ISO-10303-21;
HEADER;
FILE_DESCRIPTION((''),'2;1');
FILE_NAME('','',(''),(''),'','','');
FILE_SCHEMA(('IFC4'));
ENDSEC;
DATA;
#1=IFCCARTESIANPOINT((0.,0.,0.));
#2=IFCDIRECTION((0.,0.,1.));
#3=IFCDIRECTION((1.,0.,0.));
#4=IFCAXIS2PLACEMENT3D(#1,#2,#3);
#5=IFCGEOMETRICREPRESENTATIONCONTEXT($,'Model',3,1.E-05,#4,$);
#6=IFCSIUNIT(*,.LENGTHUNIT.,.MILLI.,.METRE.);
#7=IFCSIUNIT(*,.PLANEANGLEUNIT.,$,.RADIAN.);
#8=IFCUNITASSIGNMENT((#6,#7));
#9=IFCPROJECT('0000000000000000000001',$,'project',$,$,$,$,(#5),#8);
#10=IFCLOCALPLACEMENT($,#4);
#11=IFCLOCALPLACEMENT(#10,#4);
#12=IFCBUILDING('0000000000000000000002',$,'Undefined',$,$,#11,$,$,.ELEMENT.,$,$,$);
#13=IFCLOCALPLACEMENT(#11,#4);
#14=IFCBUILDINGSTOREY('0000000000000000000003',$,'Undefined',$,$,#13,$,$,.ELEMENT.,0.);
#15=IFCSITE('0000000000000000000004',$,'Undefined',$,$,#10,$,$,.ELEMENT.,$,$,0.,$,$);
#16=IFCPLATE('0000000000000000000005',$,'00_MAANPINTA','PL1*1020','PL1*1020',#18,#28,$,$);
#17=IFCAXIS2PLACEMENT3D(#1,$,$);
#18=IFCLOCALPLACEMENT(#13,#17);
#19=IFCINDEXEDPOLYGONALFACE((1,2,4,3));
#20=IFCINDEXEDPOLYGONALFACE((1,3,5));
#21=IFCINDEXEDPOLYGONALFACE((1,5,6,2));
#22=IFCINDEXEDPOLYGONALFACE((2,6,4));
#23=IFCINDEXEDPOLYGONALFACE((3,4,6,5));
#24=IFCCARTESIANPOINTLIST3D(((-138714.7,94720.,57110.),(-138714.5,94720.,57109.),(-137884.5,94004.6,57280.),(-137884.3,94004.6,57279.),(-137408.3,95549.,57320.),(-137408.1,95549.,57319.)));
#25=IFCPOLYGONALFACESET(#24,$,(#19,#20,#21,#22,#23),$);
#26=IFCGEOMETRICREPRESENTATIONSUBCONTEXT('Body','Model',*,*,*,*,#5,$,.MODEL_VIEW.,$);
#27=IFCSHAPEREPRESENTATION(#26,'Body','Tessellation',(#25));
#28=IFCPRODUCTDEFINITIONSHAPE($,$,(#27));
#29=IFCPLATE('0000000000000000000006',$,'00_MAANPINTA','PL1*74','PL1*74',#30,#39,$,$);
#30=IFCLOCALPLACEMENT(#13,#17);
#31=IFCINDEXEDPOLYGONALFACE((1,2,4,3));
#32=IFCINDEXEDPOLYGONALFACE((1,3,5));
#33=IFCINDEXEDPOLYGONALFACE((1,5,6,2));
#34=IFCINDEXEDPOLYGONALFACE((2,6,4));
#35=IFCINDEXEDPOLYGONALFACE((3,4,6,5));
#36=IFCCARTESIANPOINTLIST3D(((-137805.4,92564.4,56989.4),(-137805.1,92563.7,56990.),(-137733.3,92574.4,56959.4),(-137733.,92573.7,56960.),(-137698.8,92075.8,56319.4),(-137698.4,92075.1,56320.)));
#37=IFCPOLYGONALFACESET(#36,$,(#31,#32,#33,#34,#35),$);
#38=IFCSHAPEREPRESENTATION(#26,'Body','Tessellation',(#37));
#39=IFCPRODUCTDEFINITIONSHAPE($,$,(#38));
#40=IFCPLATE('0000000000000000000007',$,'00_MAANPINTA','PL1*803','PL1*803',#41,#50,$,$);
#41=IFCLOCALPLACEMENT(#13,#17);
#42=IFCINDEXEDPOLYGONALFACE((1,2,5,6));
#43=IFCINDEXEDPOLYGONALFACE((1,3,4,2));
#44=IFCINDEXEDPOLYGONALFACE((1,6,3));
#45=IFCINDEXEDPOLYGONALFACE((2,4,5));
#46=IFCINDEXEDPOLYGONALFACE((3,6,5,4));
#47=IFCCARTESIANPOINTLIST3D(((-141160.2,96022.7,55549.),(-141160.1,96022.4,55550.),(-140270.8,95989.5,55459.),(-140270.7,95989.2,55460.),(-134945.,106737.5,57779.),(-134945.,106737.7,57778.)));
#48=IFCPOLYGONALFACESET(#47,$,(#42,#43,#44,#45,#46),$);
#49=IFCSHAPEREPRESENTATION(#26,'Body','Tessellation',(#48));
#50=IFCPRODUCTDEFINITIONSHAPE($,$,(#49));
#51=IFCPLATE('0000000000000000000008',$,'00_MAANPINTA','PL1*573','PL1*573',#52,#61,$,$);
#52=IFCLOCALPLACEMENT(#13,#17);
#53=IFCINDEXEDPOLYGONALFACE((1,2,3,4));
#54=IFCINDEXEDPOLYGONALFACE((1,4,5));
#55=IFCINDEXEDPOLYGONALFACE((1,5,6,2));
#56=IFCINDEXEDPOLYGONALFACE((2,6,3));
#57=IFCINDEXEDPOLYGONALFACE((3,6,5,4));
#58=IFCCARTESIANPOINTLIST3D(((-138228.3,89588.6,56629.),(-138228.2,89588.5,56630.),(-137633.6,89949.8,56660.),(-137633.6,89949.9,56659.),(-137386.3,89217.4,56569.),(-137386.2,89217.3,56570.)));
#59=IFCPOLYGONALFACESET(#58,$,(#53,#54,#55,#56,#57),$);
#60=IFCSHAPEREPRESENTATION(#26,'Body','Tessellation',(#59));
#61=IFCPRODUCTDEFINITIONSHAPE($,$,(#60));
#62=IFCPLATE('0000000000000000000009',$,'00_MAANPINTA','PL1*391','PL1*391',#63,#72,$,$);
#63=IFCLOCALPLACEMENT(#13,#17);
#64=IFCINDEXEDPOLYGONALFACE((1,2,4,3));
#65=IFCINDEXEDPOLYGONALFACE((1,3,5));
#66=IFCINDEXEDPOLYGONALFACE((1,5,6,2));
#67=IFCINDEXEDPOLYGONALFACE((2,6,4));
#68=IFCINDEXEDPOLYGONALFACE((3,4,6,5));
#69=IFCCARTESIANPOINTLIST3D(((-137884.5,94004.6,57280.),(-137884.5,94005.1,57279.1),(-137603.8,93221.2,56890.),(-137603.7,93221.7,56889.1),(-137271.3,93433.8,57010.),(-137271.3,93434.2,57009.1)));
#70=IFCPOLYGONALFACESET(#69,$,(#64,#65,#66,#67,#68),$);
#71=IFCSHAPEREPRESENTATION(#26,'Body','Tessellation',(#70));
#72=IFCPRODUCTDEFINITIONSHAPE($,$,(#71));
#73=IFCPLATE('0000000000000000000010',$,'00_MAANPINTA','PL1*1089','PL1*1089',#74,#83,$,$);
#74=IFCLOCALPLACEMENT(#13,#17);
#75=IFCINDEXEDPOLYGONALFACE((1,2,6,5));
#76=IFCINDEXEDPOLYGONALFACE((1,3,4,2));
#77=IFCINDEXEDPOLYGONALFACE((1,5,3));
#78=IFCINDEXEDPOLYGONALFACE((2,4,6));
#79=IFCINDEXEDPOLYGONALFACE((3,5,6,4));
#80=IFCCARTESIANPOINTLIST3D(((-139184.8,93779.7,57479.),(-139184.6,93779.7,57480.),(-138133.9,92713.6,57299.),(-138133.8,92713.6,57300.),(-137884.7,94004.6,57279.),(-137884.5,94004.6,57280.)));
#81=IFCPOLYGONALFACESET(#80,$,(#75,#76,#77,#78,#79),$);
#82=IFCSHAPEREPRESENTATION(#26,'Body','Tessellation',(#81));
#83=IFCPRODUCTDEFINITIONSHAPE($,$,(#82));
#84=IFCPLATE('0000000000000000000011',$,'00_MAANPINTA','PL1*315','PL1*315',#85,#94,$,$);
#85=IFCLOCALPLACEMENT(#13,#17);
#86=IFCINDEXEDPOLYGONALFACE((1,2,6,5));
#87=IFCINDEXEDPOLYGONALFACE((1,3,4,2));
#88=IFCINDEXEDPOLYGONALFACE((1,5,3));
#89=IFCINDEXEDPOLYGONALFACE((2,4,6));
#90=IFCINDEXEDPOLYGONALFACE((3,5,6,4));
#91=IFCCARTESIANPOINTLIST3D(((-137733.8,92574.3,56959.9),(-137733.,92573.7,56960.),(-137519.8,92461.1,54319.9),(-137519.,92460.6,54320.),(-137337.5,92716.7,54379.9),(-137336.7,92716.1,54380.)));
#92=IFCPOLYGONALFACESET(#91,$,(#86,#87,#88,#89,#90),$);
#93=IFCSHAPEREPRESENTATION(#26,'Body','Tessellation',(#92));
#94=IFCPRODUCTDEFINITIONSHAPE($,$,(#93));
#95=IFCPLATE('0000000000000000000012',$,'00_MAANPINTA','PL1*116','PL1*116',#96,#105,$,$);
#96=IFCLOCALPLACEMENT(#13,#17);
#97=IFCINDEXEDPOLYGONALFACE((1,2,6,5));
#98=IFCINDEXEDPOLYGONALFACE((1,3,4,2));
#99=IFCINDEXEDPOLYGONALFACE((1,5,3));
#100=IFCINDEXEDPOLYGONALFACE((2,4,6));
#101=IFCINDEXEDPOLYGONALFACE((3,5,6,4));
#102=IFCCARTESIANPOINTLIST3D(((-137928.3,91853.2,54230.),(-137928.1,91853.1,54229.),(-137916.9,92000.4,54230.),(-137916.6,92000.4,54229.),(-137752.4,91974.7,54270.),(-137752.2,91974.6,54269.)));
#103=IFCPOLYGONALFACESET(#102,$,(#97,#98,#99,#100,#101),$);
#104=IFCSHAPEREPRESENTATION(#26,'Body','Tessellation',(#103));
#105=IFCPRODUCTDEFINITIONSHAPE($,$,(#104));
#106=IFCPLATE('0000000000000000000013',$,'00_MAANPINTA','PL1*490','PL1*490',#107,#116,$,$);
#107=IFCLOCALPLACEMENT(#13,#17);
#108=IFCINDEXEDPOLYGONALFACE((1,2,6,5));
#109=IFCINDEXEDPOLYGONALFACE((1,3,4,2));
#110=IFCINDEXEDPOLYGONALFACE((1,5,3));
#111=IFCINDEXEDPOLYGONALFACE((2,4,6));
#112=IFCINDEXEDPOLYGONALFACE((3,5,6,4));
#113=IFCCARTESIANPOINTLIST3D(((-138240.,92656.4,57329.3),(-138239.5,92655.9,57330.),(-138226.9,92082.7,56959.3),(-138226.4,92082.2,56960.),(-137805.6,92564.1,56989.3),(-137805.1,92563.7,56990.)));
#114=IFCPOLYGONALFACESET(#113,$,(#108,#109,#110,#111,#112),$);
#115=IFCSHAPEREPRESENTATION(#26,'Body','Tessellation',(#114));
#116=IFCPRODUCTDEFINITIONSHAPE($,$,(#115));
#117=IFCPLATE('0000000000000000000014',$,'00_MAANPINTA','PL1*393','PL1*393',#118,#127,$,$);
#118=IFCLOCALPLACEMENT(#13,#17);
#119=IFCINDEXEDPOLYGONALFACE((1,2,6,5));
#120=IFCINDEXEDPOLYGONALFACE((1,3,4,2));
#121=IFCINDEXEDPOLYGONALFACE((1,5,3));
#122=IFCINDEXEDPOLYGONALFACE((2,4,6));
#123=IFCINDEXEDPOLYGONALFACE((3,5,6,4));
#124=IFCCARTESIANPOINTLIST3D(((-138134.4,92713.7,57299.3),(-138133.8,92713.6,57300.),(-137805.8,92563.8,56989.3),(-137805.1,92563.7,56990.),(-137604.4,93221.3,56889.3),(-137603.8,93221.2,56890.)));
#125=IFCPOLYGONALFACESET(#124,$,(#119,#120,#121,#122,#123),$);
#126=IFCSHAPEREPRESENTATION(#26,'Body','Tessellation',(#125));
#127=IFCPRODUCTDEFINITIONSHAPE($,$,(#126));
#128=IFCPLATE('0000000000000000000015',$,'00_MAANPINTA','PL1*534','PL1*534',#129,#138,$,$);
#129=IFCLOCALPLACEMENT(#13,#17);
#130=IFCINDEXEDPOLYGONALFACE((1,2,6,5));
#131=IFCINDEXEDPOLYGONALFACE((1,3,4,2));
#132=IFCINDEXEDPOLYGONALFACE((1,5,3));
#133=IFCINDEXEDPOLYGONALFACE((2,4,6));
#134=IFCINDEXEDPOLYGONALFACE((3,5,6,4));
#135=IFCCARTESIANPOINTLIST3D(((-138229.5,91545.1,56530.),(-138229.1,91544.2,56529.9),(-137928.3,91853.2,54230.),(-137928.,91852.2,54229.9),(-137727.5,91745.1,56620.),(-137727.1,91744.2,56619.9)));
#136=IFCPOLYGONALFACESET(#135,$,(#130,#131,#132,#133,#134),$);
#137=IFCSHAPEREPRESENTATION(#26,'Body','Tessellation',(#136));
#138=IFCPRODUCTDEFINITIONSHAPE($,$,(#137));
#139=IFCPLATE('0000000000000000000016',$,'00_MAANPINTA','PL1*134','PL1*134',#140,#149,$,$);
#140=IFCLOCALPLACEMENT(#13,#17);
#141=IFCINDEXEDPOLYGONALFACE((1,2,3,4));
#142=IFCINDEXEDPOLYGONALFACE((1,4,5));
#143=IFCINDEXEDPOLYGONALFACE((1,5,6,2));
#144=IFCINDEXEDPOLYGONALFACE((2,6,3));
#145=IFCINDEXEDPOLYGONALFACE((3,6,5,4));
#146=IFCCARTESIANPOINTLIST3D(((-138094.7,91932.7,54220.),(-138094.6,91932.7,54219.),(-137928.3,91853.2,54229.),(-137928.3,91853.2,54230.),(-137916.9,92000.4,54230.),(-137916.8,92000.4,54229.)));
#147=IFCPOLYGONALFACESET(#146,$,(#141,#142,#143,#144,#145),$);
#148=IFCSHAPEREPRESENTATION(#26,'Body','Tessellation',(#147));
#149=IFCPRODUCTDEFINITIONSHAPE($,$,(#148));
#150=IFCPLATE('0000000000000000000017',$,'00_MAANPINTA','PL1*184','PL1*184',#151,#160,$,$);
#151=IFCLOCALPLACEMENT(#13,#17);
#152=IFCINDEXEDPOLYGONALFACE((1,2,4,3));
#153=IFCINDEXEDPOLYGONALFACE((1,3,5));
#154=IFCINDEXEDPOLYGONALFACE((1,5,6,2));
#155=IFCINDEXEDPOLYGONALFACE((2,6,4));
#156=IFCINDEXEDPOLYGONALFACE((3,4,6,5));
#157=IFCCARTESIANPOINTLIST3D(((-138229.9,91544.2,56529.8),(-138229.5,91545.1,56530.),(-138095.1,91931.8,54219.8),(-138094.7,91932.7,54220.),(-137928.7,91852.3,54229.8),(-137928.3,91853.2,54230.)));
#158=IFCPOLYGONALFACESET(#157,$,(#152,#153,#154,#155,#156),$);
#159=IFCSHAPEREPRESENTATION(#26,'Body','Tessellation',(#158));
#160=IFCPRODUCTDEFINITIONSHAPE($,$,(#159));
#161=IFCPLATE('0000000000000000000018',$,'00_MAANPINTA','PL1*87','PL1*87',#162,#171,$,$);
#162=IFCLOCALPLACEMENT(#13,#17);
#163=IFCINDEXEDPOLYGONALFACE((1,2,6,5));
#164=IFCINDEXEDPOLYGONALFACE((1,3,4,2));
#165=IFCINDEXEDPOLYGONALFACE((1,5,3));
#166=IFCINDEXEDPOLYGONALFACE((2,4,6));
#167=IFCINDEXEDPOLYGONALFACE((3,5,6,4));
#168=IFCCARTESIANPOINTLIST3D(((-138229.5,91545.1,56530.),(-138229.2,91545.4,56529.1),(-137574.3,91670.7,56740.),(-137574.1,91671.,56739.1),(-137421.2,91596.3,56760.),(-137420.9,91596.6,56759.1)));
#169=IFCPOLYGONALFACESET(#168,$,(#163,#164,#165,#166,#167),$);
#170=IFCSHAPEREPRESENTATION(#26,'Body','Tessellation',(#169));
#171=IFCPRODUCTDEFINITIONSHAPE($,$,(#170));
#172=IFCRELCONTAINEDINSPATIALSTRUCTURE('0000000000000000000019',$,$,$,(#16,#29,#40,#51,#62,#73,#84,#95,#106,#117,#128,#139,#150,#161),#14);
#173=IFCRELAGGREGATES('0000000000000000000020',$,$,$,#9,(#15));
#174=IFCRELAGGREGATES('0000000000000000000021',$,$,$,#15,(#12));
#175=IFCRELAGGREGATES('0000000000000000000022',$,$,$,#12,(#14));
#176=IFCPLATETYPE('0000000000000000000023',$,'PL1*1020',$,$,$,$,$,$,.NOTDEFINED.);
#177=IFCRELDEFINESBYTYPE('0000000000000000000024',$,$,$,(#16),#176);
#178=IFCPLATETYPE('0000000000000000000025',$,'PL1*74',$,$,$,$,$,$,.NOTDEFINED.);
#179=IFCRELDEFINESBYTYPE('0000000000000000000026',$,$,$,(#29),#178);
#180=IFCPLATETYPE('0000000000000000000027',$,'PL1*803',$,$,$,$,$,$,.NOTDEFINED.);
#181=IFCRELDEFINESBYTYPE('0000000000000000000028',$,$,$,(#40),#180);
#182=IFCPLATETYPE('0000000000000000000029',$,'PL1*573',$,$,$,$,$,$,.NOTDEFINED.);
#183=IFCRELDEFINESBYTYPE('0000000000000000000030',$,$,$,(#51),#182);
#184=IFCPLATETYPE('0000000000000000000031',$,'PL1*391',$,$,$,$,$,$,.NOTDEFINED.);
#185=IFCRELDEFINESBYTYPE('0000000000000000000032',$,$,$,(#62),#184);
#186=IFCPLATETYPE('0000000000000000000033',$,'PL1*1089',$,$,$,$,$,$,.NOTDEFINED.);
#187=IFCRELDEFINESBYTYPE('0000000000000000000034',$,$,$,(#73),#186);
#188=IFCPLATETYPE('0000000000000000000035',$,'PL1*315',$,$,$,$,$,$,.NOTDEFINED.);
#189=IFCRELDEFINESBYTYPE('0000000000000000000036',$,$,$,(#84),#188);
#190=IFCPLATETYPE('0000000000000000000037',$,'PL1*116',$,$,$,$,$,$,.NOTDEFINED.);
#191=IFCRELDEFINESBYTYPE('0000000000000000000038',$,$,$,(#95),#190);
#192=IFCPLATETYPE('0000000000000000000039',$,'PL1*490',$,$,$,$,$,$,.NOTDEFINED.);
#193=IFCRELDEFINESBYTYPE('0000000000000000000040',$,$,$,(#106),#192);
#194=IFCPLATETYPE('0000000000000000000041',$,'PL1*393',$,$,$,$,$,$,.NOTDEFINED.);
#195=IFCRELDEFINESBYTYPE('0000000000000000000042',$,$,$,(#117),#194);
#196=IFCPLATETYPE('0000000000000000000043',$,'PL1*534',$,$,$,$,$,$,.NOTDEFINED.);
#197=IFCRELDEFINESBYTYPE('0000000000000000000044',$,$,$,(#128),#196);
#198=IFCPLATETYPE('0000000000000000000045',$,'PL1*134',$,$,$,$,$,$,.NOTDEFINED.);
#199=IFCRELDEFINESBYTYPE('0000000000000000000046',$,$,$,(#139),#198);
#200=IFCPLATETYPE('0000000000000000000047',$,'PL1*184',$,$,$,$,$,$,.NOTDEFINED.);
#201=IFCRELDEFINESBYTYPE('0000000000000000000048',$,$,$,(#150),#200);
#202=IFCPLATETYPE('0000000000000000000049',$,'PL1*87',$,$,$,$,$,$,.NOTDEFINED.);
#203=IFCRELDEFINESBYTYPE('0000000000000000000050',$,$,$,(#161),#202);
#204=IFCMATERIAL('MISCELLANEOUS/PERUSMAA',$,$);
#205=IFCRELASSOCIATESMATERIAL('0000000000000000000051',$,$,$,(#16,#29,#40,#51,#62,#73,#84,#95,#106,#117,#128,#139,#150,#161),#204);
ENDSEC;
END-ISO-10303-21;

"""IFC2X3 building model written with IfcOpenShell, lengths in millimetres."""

from ifc_helpers import new_model, si_unit, frame, origin_with_axes, place, context, subcontext, project, spatial, polyline, outline, extrude, material, type_object, element, save


model = new_model("IFC2X3")

# Units and contexts
model_context = context("Model", 3, precision=1e-05, world=origin_with_axes())
body_context = subcontext(model_context, "Body", "Model", "MODEL_VIEW")
ifc_project = project(units=[si_unit("LENGTHUNIT", "METRE", prefix="MILLI"), si_unit("PLANEANGLEUNIT", "RADIAN")], contexts=[model_context])

# Site, building, storey
site_placement = place(None, origin_with_axes())
site = spatial("IfcSite", under=ifc_project, at=site_placement, Name="Undefined", CompositionType="ELEMENT", RefElevation=0.0)
building_placement = place(site_placement, origin_with_axes())
building = spatial("IfcBuilding", under=site, at=building_placement, Name="Undefined", CompositionType="ELEMENT")
storey_placement = place(building_placement, origin_with_axes())
storey = spatial("IfcBuildingStorey", under=building, at=storey_placement, Name="Undefined", CompositionType="ELEMENT", Elevation=0.0)

# Plates
ifc_material = material(Name="MISCELLANEOUS/PERUSMAA")
plate_type_1 = type_object("IfcPlateType", Name="PL1*1020", PredefinedType="NOTDEFINED")
plate_1_placement = place(storey_placement, frame((-138714.6, 94720.0, 57109.5), z_axis=(0.17653, -0.028947, -0.98387), x_axis=(0.836665, 0.530945, 0.134497)))
element("IfcPlate", 1, at=plate_1_placement, inside=storey, type_object=plate_type_1, material=ifc_material, Name="00_MAANPINTA", Description="PL1*1020", ObjectType="PL1*1020", context=body_context, shape_type="SweptSolid", body=[
    extrude(outline(polyline([(0.0, 0.0), (1561.4, 0.0), (337.6, 1056.4), (0.0, 0.0)])), frame((0.0, 0.0, -0.5), z_axis=(0.0, 0.0, 1.0), x_axis=(1.0, 0.0, 0.0)), (0.0, 0.0, 1.0), 1.0),
])
plate_type_2 = type_object("IfcPlateType", Name="PL1*74", PredefinedType="NOTDEFINED")
plate_2_placement = place(storey_placement, frame((-137805.3, 92564.0, 56989.7), z_axis=(-0.346171, 0.730931, -0.588138), x_axis=(0.91579, 0.127151, -0.381)))
element("IfcPlate", 2, at=plate_2_placement, inside=storey, type_object=plate_type_2, material=ifc_material, Name="00_MAANPINTA", Description="PL1*74", ObjectType="PL1*74", context=body_context, shape_type="SweptSolid", body=[
    extrude(outline(polyline([(0.0, 0.0), (78.7, 0.0), (290.8, 783.8), (0.0, 0.0)])), frame((0.0, 0.0, -0.5), z_axis=(0.0, 0.0, 1.0), x_axis=(1.0, 0.0, 0.0)), (0.0, 0.0, 1.0), 1.0),
])
plate_type_3 = type_object("IfcPlateType", Name="PL1*803", PredefinedType="NOTDEFINED")
plate_3_placement = place(storey_placement, frame((-140270.8, 95989.3, 55459.5), z_axis=(-0.088133, 0.251616, -0.963806), x_axis=(-0.994232, 0.037139, 0.10061)))
element("IfcPlate", 3, at=plate_3_placement, inside=storey, type_object=plate_type_3, material=ifc_material, Name="00_MAANPINTA", Description="PL1*803", ObjectType="PL1*803", context=body_context, shape_type="SweptSolid", body=[
    extrude(outline(polyline([(0.0, 0.0), (894.5, 0.0), (-4662.6, 11292.8), (0.0, 0.0)])), frame((0.0, 0.0, -0.5), z_axis=(0.0, 0.0, 1.0), x_axis=(1.0, 0.0, 0.0)), (0.0, 0.0, 1.0), 1.0),
])
plate_type_4 = type_object("IfcPlateType", Name="PL1*573", PredefinedType="NOTDEFINED")
plate_4_placement = place(storey_placement, frame((-138228.3, 89588.6, 56629.5), z_axis=(-0.019941, 0.115282, -0.993133), x_axis=(0.853834, 0.51876, 0.043073)))
element("IfcPlate", 4, at=plate_4_placement, inside=storey, type_object=plate_type_4, material=ifc_material, Name="00_MAANPINTA", Description="PL1*573", ObjectType="PL1*573", context=body_context, shape_type="SweptSolid", body=[
    extrude(outline(polyline([(0.0, 0.0), (696.5, 0.0), (523.8, 759.0), (0.0, 0.0)])), frame((0.0, 0.0, -0.5), z_axis=(0.0, 0.0, 1.0), x_axis=(1.0, 0.0, 0.0)), (0.0, 0.0, 1.0), 1.0),
])
plate_type_5 = type_object("IfcPlateType", Name="PL1*391", PredefinedType="NOTDEFINED")
plate_5_placement = place(storey_placement, frame((-137884.5, 94004.8, 57279.6), z_axis=(0.030883, 0.4543, -0.890313), x_axis=(0.696643, -0.648527, -0.306759)))
element("IfcPlate", 5, at=plate_5_placement, inside=storey, type_object=plate_type_5, material=ifc_material, Name="00_MAANPINTA", Description="PL1*391", ObjectType="PL1*391", context=body_context, shape_type="SweptSolid", body=[
    extrude(outline(polyline([(0.0, 0.0), (880.2, 0.0), (823.2, 408.5), (0.0, 0.0)])), frame((0.0, 0.0, -0.5), z_axis=(0.0, 0.0, 1.0), x_axis=(1.0, 0.0, 0.0)), (0.0, 0.0, 1.0), 1.0),
])
plate_type_6 = type_object("IfcPlateType", Name="PL1*1089", PredefinedType="NOTDEFINED")
plate_6_placement = place(storey_placement, frame((-139184.7, 93779.7, 57479.5), z_axis=(-0.154485, 0.014523, -0.987888), x_axis=(0.974238, 0.168521, -0.149873)))
element("IfcPlate", 6, at=plate_6_placement, inside=storey, type_object=plate_type_6, material=ifc_material, Name="00_MAANPINTA", Description="PL1*1089", ObjectType="PL1*1089", context=body_context, shape_type="SweptSolid", body=[
    extrude(outline(polyline([(0.0, 0.0), (1334.5, 0.0), (871.1, 1230.7), (0.0, 0.0)])), frame((0.0, 0.0, -0.5), z_axis=(0.0, 0.0, 1.0), x_axis=(1.0, 0.0, 0.0)), (0.0, 0.0, 1.0), 1.0),
])
plate_type_7 = type_object("IfcPlateType", Name="PL1*315", PredefinedType="NOTDEFINED")
plate_7_placement = place(storey_placement, frame((-137733.4, 92574.0, 56960.0), z_axis=(-0.800653, 0.592287, -0.090286), x_axis=(0.151586, 0.054468, -0.986942)))
element("IfcPlate", 7, at=plate_7_placement, inside=storey, type_object=plate_type_7, material=ifc_material, Name="00_MAANPINTA", Description="PL1*315", ObjectType="PL1*315", context=body_context, shape_type="SweptSolid", body=[
    extrude(outline(polyline([(0.0, 0.0), (2614.1, 0.0), (2631.8, 319.0), (0.0, 0.0)])), frame((0.0, 0.0, -0.5), z_axis=(0.0, 0.0, 1.0), x_axis=(1.0, 0.0, 0.0)), (0.0, 0.0, 1.0), 1.0),
])
plate_type_8 = type_object("IfcPlateType", Name="PL1*116", PredefinedType="NOTDEFINED")
plate_8_placement = place(storey_placement, frame((-137916.8, 92000.4, 54229.5), z_axis=(0.233639, -0.018186, -0.972153), x_axis=(0.960645, -0.150179, 0.233682)))
element("IfcPlate", 8, at=plate_8_placement, inside=storey, type_object=plate_type_8, material=ifc_material, Name="00_MAANPINTA", Description="PL1*116", ObjectType="PL1*116", context=body_context, shape_type="SweptSolid", body=[
    extrude(outline(polyline([(0.0, 0.0), (171.2, 0.0), (11.1, 147.2), (0.0, 0.0)])), frame((0.0, 0.0, -0.5), z_axis=(0.0, 0.0, 1.0), x_axis=(1.0, 0.0, 0.0)), (0.0, 0.0, 1.0), 1.0),
])
plate_type_9 = type_object("IfcPlateType", Name="PL1*490", PredefinedType="NOTDEFINED")
plate_9_placement = place(storey_placement, frame((-138226.6, 92082.4, 56959.6), z_axis=(-0.48125, 0.467324, -0.741625), x_axis=(-0.019169, 0.840227, 0.541896)))
element("IfcPlate", 9, at=plate_9_placement, inside=storey, type_object=plate_type_9, material=ifc_material, Name="00_MAANPINTA", Description="PL1*490", ObjectType="PL1*490", context=body_context, shape_type="SweptSolid", body=[
    extrude(outline(polyline([(0.0, 0.0), (682.8, 0.0), (412.7, 489.8), (0.0, 0.0)])), frame((0.0, 0.0, -0.5), z_axis=(0.0, 0.0, 1.0), x_axis=(1.0, 0.0, 0.0)), (0.0, 0.0, 1.0), 1.0),
])
plate_type_10 = type_object("IfcPlateType", Name="PL1*393", PredefinedType="NOTDEFINED")
plate_10_placement = place(storey_placement, frame((-137805.4, 92563.7, 56989.6), z_axis=(-0.661536, 0.0893, -0.744577), x_axis=(-0.690464, 0.314902, 0.651226)))
element("IfcPlate", 10, at=plate_10_placement, inside=storey, type_object=plate_type_10, material=ifc_material, Name="00_MAANPINTA", Description="PL1*393", ObjectType="PL1*393", context=body_context, shape_type="SweptSolid", body=[
    extrude(outline(polyline([(0.0, 0.0), (476.0, 0.0), (2.9, 694.9), (0.0, 0.0)])), frame((0.0, 0.0, -0.5), z_axis=(0.0, 0.0, 1.0), x_axis=(1.0, 0.0, 0.0)), (0.0, 0.0, 1.0), 1.0),
])
plate_type_11 = type_object("IfcPlateType", Name="PL1*534", PredefinedType="NOTDEFINED")
plate_11_placement = place(storey_placement, frame((-138229.3, 91544.6, 56530.0), z_axis=(0.380576, -0.921813, -0.073642), x_axis=(0.128696, 0.131656, -0.982906)))
element("IfcPlate", 11, at=plate_11_placement, inside=storey, type_object=plate_type_11, material=ifc_material, Name="00_MAANPINTA", Description="PL1*534", ObjectType="PL1*534", context=body_context, shape_type="SweptSolid", body=[
    extrude(outline(polyline([(0.0, 0.0), (2340.0, 0.0), (2.5, 547.8), (0.0, 0.0)])), frame((0.0, 0.0, -0.5), z_axis=(0.0, 0.0, 1.0), x_axis=(1.0, 0.0, 0.0)), (0.0, 0.0, 1.0), 1.0),
])
plate_type_12 = type_object("IfcPlateType", Name="PL1*134", PredefinedType="NOTDEFINED")
plate_12_placement = place(storey_placement, frame((-137928.3, 91853.2, 54229.5), z_axis=(0.057856, -0.004503, -0.998315), x_axis=(-0.900895, 0.430645, -0.054153)))
element("IfcPlate", 12, at=plate_12_placement, inside=storey, type_object=plate_type_12, material=ifc_material, Name="00_MAANPINTA", Description="PL1*134", ObjectType="PL1*134", context=body_context, shape_type="SweptSolid", body=[
    extrude(outline(polyline([(0.0, 0.0), (184.7, 0.0), (53.1, 137.8), (0.0, 0.0)])), frame((0.0, 0.0, -0.5), z_axis=(0.0, 0.0, 1.0), x_axis=(1.0, 0.0, 0.0)), (0.0, 0.0, 1.0), 1.0),
])
plate_type_13 = type_object("IfcPlateType", Name="PL1*184", PredefinedType="NOTDEFINED")
plate_13_placement = place(storey_placement, frame((-138229.7, 91544.6, 56529.9), z_axis=(-0.416162, -0.892481, -0.174033), x_axis=(0.05745, 0.165205, -0.984585)))
element("IfcPlate", 13, at=plate_13_placement, inside=storey, type_object=plate_type_13, material=ifc_material, Name="00_MAANPINTA", Description="PL1*184", ObjectType="PL1*184", context=body_context, shape_type="SweptSolid", body=[
    extrude(outline(polyline([(0.0, 0.0), (2346.2, 0.0), (2332.7, 184.2), (0.0, 0.0)])), frame((0.0, 0.0, -0.5), z_axis=(0.0, 0.0, 1.0), x_axis=(1.0, 0.0, 0.0)), (0.0, 0.0, 1.0), 1.0),
])
plate_type_14 = type_object("IfcPlateType", Name="PL1*87", PredefinedType="NOTDEFINED")
plate_14_placement = place(storey_placement, frame((-138229.4, 91545.2, 56529.5), z_axis=(0.2488, 0.261445, -0.932601), x_axis=(0.936784, 0.17964, 0.300276)))
element("IfcPlate", 14, at=plate_14_placement, inside=storey, type_object=plate_type_14, material=ifc_material, Name="00_MAANPINTA", Description="PL1*87", ObjectType="PL1*87", context=body_context, shape_type="SweptSolid", body=[
    extrude(outline(polyline([(0.0, 0.0), (699.4, 0.0), (835.5, 104.3), (0.0, 0.0)])), frame((0.0, 0.0, -0.5), z_axis=(0.0, 0.0, 1.0), x_axis=(1.0, 0.0, 0.0)), (0.0, 0.0, 1.0), 1.0),
])

save(model, "model.ifc")
